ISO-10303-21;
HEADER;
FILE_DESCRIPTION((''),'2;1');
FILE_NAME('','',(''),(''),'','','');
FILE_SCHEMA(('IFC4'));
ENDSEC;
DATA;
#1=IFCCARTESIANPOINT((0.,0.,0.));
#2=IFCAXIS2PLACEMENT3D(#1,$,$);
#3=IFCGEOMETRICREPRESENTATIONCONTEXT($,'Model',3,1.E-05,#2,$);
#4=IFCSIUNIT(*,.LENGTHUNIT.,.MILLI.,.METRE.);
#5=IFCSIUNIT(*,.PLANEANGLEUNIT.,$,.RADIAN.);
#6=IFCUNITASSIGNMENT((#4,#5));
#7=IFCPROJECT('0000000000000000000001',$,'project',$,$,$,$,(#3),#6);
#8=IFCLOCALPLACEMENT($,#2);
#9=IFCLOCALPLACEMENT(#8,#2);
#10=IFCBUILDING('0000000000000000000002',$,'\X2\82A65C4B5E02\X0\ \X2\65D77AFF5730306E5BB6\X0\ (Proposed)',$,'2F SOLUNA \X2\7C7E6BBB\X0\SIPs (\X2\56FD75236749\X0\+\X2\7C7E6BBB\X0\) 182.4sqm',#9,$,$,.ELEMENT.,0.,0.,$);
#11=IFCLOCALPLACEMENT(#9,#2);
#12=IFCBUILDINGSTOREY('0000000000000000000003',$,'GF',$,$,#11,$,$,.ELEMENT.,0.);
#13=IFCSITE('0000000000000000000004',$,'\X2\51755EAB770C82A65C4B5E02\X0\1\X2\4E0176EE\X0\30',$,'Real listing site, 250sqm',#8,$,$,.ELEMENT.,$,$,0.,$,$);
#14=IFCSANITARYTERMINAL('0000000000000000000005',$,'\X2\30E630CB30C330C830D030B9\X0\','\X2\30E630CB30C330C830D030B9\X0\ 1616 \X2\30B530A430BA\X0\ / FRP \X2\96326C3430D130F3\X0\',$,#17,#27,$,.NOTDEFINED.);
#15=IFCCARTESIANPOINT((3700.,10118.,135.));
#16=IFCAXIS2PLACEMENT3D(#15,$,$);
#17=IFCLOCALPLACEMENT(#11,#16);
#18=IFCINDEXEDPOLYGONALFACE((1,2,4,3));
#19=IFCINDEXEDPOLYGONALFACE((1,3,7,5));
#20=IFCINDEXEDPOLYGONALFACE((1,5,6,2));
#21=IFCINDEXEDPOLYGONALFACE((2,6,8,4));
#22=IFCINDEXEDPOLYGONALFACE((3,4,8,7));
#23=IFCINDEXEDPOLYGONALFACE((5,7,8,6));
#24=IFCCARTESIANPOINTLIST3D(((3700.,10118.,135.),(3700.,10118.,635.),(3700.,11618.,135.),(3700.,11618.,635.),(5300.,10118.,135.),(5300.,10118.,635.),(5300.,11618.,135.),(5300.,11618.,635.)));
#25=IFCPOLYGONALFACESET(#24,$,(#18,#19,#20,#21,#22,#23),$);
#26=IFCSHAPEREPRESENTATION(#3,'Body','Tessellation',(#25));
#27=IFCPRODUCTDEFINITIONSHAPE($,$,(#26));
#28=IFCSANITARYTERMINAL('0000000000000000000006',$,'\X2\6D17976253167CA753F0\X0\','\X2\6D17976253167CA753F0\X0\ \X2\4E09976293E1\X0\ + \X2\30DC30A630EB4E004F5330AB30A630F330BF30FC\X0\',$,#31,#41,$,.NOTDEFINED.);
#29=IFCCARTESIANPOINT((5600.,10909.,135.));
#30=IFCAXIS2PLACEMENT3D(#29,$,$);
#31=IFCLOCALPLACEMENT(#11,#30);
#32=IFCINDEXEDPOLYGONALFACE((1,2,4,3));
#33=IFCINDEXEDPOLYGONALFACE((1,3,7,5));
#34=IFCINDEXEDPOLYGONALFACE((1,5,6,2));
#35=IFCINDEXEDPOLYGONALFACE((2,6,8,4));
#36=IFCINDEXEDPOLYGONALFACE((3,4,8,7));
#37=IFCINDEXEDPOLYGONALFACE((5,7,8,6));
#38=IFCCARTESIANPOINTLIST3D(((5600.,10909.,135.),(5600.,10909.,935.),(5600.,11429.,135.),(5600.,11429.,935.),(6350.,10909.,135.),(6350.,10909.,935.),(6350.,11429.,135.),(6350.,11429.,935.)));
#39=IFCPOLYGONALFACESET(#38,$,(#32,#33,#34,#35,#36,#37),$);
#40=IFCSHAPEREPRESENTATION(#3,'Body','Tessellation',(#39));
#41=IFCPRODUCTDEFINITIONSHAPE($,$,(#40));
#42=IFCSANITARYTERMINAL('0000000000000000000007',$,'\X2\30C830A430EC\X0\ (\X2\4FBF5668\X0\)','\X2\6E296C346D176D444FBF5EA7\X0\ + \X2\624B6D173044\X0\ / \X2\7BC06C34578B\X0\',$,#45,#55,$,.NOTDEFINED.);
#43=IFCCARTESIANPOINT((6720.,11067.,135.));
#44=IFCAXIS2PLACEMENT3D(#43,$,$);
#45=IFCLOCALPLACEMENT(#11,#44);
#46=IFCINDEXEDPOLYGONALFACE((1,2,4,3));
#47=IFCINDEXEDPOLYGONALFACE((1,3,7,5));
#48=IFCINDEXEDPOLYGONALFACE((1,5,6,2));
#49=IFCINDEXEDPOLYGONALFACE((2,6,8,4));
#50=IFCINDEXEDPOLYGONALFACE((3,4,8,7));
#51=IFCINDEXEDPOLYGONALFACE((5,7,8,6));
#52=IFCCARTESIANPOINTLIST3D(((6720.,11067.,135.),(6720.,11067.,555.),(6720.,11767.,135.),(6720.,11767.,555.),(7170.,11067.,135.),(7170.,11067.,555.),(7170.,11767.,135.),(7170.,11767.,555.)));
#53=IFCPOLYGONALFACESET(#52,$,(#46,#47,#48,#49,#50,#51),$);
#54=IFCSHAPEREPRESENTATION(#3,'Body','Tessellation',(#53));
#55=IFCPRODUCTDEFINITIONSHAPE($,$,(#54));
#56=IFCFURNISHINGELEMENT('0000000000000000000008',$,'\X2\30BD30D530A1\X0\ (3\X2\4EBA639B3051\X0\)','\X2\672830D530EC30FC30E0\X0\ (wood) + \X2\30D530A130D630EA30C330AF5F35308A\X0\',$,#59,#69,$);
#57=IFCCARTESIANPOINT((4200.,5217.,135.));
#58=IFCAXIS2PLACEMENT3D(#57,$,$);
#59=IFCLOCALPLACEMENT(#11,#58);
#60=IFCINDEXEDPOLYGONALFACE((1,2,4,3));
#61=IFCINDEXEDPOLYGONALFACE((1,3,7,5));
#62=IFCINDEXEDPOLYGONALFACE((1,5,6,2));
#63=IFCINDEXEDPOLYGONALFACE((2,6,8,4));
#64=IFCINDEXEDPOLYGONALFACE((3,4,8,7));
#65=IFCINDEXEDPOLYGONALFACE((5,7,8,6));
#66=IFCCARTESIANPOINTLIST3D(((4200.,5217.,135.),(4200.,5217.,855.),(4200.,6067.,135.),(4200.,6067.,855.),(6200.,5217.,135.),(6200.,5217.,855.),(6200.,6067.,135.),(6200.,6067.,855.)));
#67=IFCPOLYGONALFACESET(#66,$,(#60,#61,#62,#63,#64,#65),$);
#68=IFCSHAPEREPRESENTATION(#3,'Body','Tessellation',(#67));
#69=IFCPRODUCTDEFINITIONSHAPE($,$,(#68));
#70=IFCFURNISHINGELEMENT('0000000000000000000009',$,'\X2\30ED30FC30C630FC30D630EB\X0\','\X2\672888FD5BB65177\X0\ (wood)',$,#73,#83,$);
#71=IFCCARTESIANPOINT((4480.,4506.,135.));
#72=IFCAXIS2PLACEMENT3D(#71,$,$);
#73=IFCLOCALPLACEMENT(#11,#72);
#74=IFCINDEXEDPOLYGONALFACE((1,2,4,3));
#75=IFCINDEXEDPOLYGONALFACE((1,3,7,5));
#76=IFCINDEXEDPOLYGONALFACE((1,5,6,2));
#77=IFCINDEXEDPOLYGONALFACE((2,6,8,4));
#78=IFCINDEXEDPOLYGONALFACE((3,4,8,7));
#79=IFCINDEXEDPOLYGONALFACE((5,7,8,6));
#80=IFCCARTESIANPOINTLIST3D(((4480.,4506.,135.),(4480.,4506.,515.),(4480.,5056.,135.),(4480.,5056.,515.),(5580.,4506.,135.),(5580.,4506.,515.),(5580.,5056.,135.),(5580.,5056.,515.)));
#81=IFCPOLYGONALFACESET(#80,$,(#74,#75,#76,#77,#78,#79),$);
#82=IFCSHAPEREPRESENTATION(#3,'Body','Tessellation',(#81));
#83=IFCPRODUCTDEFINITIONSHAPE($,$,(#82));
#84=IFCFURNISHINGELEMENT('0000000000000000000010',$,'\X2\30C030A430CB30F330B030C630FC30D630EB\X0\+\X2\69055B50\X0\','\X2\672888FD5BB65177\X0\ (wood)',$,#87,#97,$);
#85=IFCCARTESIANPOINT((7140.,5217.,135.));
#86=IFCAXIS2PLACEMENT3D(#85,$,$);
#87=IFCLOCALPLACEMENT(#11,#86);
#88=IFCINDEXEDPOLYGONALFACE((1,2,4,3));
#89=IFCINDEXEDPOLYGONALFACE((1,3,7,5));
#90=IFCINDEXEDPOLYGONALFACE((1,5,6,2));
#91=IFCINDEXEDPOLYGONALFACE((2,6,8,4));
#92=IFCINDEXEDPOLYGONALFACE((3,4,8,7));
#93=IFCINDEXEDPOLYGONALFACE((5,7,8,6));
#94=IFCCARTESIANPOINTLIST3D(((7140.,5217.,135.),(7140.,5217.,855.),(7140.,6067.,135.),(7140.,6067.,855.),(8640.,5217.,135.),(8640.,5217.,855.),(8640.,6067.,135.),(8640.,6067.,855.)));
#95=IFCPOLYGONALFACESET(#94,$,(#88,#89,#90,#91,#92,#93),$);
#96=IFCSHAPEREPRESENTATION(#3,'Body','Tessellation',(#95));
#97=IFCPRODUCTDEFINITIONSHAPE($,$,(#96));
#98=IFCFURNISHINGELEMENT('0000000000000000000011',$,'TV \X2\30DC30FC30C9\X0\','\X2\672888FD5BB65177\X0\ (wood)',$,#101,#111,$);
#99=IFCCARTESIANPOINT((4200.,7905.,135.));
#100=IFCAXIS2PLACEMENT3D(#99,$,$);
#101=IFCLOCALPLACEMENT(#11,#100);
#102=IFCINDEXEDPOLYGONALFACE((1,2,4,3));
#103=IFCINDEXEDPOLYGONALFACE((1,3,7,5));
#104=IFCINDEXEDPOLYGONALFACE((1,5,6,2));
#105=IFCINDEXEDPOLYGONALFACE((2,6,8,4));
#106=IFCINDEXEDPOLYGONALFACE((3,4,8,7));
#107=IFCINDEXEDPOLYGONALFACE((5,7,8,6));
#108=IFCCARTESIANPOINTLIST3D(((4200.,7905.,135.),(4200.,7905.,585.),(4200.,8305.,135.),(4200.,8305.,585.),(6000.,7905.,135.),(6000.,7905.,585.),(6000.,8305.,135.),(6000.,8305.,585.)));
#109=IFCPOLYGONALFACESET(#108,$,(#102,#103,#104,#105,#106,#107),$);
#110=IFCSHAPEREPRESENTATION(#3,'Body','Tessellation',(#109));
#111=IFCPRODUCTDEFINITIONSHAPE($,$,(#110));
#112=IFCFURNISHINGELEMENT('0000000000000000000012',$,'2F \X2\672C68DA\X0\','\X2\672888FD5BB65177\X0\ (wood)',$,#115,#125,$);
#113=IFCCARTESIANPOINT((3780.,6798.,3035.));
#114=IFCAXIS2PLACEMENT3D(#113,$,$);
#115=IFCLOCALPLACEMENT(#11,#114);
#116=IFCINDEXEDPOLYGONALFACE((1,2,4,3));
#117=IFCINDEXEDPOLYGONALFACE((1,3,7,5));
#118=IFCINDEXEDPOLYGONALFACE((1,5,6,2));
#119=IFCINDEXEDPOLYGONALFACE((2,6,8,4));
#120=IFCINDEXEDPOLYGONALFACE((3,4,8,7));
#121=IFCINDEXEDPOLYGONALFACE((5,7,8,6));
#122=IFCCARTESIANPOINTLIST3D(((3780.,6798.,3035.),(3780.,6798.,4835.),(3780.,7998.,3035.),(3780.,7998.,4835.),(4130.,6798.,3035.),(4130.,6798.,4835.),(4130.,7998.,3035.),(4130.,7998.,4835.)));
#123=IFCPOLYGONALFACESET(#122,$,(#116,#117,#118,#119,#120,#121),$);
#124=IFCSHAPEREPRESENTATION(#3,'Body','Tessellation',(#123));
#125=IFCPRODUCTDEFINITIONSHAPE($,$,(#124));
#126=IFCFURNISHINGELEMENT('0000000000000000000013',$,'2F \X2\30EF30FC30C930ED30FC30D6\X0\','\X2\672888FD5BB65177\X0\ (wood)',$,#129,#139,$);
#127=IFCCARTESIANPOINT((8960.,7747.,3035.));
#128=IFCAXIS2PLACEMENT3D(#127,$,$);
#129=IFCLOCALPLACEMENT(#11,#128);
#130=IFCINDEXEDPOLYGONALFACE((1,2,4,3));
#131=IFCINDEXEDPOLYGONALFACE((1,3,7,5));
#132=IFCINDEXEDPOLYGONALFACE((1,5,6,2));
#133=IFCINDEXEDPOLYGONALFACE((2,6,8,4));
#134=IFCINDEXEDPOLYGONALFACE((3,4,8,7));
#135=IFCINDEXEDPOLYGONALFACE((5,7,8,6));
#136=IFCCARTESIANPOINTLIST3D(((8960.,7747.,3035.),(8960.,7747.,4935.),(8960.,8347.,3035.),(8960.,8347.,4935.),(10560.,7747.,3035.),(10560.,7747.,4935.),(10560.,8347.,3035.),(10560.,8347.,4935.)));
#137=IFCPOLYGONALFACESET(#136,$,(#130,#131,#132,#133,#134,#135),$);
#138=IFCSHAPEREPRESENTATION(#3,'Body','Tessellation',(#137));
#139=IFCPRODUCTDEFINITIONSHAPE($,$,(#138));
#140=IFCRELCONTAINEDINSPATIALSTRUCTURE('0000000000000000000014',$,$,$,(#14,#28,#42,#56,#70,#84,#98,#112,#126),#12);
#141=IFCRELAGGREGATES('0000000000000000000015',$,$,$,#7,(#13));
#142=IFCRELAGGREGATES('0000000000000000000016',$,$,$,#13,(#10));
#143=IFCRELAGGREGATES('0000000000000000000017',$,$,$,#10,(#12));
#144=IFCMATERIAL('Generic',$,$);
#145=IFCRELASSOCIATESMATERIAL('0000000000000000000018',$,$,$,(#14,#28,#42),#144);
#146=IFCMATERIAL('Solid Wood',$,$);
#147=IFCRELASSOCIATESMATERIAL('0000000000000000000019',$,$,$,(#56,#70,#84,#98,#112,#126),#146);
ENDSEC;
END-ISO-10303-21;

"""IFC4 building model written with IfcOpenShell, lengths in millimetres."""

from ifc_helpers import new_model, si_unit, frame, frame_2d, origin, place, context, project, spatial, rectangle, extrude, material, element, save


model = new_model("IFC4")

# Units and contexts
model_context = context("Model", 3, precision=1e-05, world=origin())
ifc_project = project(units=[si_unit("LENGTHUNIT", "METRE", prefix="MILLI"), si_unit("PLANEANGLEUNIT", "RADIAN")], contexts=[model_context])

# Site, building, storey
site_placement = place(None, origin())
site = spatial("IfcSite", under=ifc_project, at=site_placement, Name="兵庫県芦屋市1丁目30", ObjectType="Real listing site, 250sqm", CompositionType="ELEMENT", RefElevation=0.0)
building_placement = place(site_placement, origin())
building = spatial("IfcBuilding", under=site, at=building_placement, Name="芦屋市 旗竿地の家 (Proposed)", ObjectType="2F SOLUNA 籾殻SIPs (国産杉+籾殻) 182.4sqm", CompositionType="ELEMENT", ElevationOfRefHeight=0.0, ElevationOfTerrain=0.0)
storey_placement = place(building_placement, origin())
storey = spatial("IfcBuildingStorey", under=building, at=storey_placement, Name="GF", CompositionType="ELEMENT", Elevation=0.0)

# Shared definitions
ifc_material_1 = material(Name="Generic")

# Shared definitions
ifc_material_2 = material(Name="Solid Wood")

# Sanitary terminals
sanitary_terminal_1_placement = place(storey_placement, frame((3700.0, 10118.0, 135.0)))
element("IfcSanitaryTerminal", 1, at=sanitary_terminal_1_placement, inside=storey, material=ifc_material_1, Name="ユニットバス", Description="ユニットバス 1616 サイズ / FRP 防水パン", PredefinedType="NOTDEFINED", context=model_context, shape_type="SweptSolid", body=[
    extrude(rectangle(XDim=1600.0, YDim=1500.0, at=frame_2d((800.0, 750.0))), frame((3700.0, 10118.0, 135.0)), (0.0, 0.0, 1.0), 500.0),
])
sanitary_terminal_2_placement = place(storey_placement, frame((5600.0, 10909.0, 135.0)))
element("IfcSanitaryTerminal", 2, at=sanitary_terminal_2_placement, inside=storey, material=ifc_material_1, Name="洗面化粧台", Description="洗面化粧台 三面鏡 + ボウル一体カウンター", PredefinedType="NOTDEFINED", context=model_context, shape_type="SweptSolid", body=[
    extrude(rectangle(XDim=750.0, YDim=520.0, at=frame_2d((375.0, 260.0))), frame((5600.0, 10909.0, 135.0)), (0.0, 0.0, 1.0), 800.0),
])
sanitary_terminal_3_placement = place(storey_placement, frame((6720.0, 11067.0, 135.0)))
element("IfcSanitaryTerminal", 3, at=sanitary_terminal_3_placement, inside=storey, material=ifc_material_1, Name="トイレ (便器)", Description="温水洗浄便座 + 手洗い / 節水型", PredefinedType="NOTDEFINED", context=model_context, shape_type="SweptSolid", body=[
    extrude(rectangle(XDim=450.0, YDim=700.0, at=frame_2d((225.0, 350.0))), frame((6720.0, 11067.0, 135.0)), (0.0, 0.0, 1.0), 420.0),
])

# Furnishing elements
furnishing_1_placement = place(storey_placement, frame((4200.0, 5217.0, 135.0)))
element("IfcFurnishingElement", 4, at=furnishing_1_placement, inside=storey, material=ifc_material_2, Name="ソファ (3人掛け)", Description="木フレーム (wood) + ファブリック張り", context=model_context, shape_type="SweptSolid", body=[
    extrude(rectangle(XDim=2000.0, YDim=850.0, at=frame_2d((1000.0, 425.0))), frame((4200.0, 5217.0, 135.0)), (0.0, 0.0, 1.0), 720.0),
])
furnishing_2_placement = place(storey_placement, frame((4480.0, 4506.0, 135.0)))
element("IfcFurnishingElement", 5, at=furnishing_2_placement, inside=storey, material=ifc_material_2, Name="ローテーブル", Description="木製家具 (wood)", context=model_context, shape_type="SweptSolid", body=[
    extrude(rectangle(XDim=1100.0, YDim=550.0, at=frame_2d((550.0, 275.0))), frame((4480.0, 4506.0, 135.0)), (0.0, 0.0, 1.0), 380.0),
])
furnishing_3_placement = place(storey_placement, frame((7140.0, 5217.0, 135.0)))
element("IfcFurnishingElement", 6, at=furnishing_3_placement, inside=storey, material=ifc_material_2, Name="ダイニングテーブル+椅子", Description="木製家具 (wood)", context=model_context, shape_type="SweptSolid", body=[
    extrude(rectangle(XDim=1500.0, YDim=850.0, at=frame_2d((750.0, 425.0))), frame((7140.0, 5217.0, 135.0)), (0.0, 0.0, 1.0), 720.0),
])
furnishing_4_placement = place(storey_placement, frame((4200.0, 7905.0, 135.0)))
element("IfcFurnishingElement", 7, at=furnishing_4_placement, inside=storey, material=ifc_material_2, Name="TV ボード", Description="木製家具 (wood)", context=model_context, shape_type="SweptSolid", body=[
    extrude(rectangle(XDim=1800.0, YDim=400.0, at=frame_2d((900.0, 200.0))), frame((4200.0, 7905.0, 135.0)), (0.0, 0.0, 1.0), 450.0),
])
furnishing_5_placement = place(storey_placement, frame((3780.0, 6798.0, 3035.0)))
element("IfcFurnishingElement", 8, at=furnishing_5_placement, inside=storey, material=ifc_material_2, Name="2F 本棚", Description="木製家具 (wood)", context=model_context, shape_type="SweptSolid", body=[
    extrude(rectangle(XDim=350.0, YDim=1200.0, at=frame_2d((175.0, 600.0))), frame((3780.0, 6798.0, 3035.0)), (0.0, 0.0, 1.0), 1800.0),
])
furnishing_6_placement = place(storey_placement, frame((8960.0, 7747.0, 3035.0)))
element("IfcFurnishingElement", 9, at=furnishing_6_placement, inside=storey, material=ifc_material_2, Name="2F ワードローブ", Description="木製家具 (wood)", context=model_context, shape_type="SweptSolid", body=[
    extrude(rectangle(XDim=1600.0, YDim=600.0, at=frame_2d((800.0, 300.0))), frame((8960.0, 7747.0, 3035.0)), (0.0, 0.0, 1.0), 1900.0),
])

save(model, "model.ifc")
